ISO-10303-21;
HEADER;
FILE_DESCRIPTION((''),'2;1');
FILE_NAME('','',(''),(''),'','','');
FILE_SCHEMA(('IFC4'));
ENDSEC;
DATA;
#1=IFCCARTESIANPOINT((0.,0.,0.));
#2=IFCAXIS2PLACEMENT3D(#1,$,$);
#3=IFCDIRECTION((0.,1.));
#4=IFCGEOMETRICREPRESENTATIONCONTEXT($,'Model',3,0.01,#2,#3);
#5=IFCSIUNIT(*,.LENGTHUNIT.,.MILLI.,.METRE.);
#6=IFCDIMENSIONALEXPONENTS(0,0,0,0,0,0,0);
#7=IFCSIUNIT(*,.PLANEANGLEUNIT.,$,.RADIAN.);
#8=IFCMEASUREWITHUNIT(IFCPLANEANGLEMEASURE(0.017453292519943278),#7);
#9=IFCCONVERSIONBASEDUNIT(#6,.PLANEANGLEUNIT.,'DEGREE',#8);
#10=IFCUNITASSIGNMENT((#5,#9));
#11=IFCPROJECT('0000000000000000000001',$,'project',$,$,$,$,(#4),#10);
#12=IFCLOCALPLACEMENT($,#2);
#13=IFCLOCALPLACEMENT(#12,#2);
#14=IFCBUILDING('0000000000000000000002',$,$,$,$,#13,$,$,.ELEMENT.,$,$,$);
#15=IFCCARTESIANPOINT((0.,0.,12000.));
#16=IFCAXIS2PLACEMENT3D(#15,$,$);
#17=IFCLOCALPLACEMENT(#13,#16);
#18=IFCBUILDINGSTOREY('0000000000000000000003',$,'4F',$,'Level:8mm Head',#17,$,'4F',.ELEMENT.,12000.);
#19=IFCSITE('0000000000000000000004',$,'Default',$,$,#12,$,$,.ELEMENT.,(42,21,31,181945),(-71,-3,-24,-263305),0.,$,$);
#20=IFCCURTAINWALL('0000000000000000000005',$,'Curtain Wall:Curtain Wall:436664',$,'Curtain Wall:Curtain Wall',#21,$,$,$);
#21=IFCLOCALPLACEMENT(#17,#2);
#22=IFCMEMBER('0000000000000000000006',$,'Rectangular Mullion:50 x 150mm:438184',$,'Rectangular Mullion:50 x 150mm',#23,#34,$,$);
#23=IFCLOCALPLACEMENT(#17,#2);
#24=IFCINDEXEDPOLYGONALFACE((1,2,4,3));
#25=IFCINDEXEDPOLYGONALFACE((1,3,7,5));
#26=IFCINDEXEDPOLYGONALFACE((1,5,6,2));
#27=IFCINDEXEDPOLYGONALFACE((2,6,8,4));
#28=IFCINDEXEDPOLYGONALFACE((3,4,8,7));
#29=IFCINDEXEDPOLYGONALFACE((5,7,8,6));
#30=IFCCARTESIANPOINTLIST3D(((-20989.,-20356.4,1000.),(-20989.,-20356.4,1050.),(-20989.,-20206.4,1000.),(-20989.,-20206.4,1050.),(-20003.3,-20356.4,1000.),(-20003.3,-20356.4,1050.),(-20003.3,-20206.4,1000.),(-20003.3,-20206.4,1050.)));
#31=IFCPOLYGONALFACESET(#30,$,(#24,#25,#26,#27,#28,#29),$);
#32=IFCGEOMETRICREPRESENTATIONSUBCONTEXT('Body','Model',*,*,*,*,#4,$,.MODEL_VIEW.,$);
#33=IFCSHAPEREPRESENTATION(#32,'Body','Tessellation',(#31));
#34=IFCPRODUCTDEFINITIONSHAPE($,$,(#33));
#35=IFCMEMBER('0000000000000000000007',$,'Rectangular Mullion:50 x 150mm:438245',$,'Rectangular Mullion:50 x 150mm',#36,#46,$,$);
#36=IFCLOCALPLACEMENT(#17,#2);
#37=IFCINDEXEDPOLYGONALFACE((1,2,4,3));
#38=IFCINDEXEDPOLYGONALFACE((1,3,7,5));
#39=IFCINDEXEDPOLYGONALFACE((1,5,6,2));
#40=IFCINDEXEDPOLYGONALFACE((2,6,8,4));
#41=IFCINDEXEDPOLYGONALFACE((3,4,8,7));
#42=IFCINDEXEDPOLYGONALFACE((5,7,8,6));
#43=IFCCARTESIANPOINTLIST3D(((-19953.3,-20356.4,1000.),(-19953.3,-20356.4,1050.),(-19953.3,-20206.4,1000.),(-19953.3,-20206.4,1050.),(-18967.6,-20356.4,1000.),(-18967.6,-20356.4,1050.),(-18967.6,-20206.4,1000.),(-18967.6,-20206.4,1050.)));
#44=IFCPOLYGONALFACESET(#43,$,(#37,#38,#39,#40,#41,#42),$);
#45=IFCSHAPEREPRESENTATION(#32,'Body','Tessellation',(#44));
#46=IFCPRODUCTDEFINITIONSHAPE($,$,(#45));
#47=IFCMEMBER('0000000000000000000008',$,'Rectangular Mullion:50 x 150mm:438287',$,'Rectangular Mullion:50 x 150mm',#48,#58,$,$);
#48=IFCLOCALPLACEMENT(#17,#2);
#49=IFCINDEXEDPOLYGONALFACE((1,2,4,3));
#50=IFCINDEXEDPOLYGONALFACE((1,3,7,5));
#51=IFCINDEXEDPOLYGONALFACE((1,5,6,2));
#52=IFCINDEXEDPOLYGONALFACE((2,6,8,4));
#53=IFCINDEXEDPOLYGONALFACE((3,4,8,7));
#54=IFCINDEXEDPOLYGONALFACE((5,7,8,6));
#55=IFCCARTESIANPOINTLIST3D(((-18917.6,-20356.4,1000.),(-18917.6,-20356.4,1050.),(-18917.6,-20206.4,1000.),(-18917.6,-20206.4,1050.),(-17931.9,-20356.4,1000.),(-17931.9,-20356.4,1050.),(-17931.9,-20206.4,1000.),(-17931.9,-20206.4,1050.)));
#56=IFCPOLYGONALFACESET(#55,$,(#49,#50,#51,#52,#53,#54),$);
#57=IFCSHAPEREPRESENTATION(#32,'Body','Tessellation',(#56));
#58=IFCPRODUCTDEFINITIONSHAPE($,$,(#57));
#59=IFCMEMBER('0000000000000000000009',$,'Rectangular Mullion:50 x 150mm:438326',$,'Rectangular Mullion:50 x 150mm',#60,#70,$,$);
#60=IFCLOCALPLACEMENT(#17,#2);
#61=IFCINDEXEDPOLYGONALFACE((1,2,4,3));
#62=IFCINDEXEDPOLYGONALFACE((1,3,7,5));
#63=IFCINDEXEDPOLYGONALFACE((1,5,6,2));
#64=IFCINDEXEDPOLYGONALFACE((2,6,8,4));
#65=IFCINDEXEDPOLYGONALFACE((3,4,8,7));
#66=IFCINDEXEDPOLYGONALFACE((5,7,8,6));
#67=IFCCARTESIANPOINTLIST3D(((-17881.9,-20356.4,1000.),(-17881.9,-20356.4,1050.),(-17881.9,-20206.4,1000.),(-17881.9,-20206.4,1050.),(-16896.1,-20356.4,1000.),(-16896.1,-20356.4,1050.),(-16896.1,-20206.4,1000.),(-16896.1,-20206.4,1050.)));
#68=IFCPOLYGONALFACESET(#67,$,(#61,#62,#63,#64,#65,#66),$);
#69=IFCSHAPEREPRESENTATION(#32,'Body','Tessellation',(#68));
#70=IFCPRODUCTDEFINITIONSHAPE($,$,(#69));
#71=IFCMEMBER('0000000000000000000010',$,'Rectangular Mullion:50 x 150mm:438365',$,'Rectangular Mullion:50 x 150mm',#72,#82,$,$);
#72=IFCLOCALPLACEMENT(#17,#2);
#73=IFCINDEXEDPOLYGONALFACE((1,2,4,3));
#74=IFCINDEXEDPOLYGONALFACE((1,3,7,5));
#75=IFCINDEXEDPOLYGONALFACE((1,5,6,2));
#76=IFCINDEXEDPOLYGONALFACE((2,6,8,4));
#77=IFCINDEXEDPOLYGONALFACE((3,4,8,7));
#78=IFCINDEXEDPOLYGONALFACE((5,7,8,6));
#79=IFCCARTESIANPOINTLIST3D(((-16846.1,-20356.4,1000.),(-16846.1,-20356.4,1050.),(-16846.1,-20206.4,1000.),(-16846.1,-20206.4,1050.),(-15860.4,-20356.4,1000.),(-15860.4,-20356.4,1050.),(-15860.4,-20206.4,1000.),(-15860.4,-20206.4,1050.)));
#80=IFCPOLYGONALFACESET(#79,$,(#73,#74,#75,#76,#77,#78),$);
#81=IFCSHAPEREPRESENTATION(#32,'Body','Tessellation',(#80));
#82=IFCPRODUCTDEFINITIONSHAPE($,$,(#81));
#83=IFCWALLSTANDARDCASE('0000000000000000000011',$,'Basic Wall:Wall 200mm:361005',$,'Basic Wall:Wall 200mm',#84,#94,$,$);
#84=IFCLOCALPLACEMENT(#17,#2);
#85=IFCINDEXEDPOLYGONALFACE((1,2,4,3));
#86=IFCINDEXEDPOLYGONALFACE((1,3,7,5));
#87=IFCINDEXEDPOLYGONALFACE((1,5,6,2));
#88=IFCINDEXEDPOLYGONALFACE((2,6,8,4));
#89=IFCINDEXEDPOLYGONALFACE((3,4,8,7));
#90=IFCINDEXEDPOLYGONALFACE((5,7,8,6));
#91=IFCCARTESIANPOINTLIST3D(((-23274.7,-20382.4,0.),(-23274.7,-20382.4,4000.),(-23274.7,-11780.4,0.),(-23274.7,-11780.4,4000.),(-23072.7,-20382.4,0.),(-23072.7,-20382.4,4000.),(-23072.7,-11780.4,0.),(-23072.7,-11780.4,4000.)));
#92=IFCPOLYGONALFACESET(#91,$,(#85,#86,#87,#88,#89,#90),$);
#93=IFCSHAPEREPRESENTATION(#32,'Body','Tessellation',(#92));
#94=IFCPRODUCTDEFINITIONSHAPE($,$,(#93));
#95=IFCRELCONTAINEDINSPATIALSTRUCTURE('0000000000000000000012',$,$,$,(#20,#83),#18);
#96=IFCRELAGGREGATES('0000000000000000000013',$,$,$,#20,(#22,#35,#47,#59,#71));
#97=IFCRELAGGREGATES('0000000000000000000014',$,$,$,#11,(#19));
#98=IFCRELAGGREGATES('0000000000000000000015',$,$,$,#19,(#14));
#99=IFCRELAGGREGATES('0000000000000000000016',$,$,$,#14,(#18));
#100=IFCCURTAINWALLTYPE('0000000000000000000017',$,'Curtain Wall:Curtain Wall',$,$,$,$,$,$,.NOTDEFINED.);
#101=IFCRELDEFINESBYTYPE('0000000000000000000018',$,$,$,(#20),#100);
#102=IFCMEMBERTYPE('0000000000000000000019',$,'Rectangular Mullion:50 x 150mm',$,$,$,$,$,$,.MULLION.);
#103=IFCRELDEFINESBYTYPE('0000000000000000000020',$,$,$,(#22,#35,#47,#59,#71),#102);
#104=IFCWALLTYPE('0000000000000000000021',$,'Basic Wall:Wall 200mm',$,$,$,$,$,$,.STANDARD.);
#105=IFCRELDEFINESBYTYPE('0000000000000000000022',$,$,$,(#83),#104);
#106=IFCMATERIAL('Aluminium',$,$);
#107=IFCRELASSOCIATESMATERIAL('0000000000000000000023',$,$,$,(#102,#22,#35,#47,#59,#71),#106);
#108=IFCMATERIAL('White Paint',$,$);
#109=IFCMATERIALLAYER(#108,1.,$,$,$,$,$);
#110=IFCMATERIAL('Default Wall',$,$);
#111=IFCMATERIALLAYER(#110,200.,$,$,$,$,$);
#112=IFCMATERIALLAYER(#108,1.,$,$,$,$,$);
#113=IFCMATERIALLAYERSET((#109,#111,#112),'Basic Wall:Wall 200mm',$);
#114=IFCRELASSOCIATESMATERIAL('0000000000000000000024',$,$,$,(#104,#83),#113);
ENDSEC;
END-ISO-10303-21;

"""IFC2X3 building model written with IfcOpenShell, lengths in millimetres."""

from ifc_helpers import new_model, entity, si_unit, converted_unit, direction, frame, frame_2d, origin, origin_2d_with_axis, place, context, subcontext, project, spatial, rectangle, extrude, source, transform, mapped, material, layer, layer_set, layer_usage, type_object, type_shapes, element, aggregate, save


model = new_model("IFC2X3")

# Units and contexts
model_context = context("Model", 3, precision=0.01, world=origin(), true_north=direction((0.0, 1.0)))
body_context = subcontext(model_context, "Body", "Model", "MODEL_VIEW")
ifc_project = project(units=[si_unit("LENGTHUNIT", "METRE", prefix="MILLI"), converted_unit("PLANEANGLEUNIT", "DEGREE", entity("IfcPlaneAngleMeasure", 0.017453292519943278), si_unit("PLANEANGLEUNIT", "RADIAN"), dimensions=[0, 0, 0, 0, 0, 0, 0])], contexts=[model_context])

# Site, building, storey
site_placement = place(None, origin())
site = spatial("IfcSite", under=ifc_project, at=site_placement, Name="Default", CompositionType="ELEMENT", RefLatitude=(42, 21, 31, 181945), RefLongitude=(-71, -3, -24, -263305), RefElevation=0.0)
building_placement = place(site_placement, origin())
building = spatial("IfcBuilding", under=site, at=building_placement, CompositionType="ELEMENT")
storey_placement = place(building_placement, frame((0.0, 0.0, 12000.0)))
storey = spatial("IfcBuildingStorey", under=building, at=storey_placement, Name="4F", ObjectType="Level:8mm Head", LongName="4F", CompositionType="ELEMENT", Elevation=12000.0)

# Curtain wall, members
curtain_wall_type = type_object("IfcCurtainWallType", Name="Curtain Wall:Curtain Wall", PredefinedType="NOTDEFINED")
curtain_wall_placement = place(storey_placement, frame((0.0, 0.0, -12000.0)))
curtain_wall = element("IfcCurtainWall", 1, at=curtain_wall_placement, inside=storey, type_object=curtain_wall_type, Name="Curtain Wall:Curtain Wall:436664", ObjectType="Curtain Wall:Curtain Wall")
ifc_material_1 = material(Name="Aluminium")
member_type_1 = type_object("IfcMemberType", Name="Rectangular Mullion:50 x 150mm", PredefinedType="MULLION", material=ifc_material_1)
shared_shape_1 = source(origin(), body_context, "Body", "SweptSolid", [
    extrude(rectangle(XDim=50.0, YDim=150.0, at=origin_2d_with_axis()), frame((-25.0, 0.0, -985.7), z_axis=(0.0, 0.0, 1.0), x_axis=(-1.0, 0.0, 0.0)), (0.0, 0.0, 1.0), 985.7),
])
type_shapes(member_type_1, [shared_shape_1])
member_1_placement = place(curtain_wall_placement, frame((-20003.3, -20281.4, 13000.0), z_axis=(1.0, 0.0, 0.0), x_axis=(0.0, 0.0, -1.0)))
member_1 = element("IfcMember", 2, at=member_1_placement, type_object=member_type_1, material=ifc_material_1, Name="Rectangular Mullion:50 x 150mm:438184", ObjectType="Rectangular Mullion:50 x 150mm", context=body_context, shape_type="MappedRepresentation", body=[
    mapped(shared_shape_1, transform((0.0, 0.0, 0.0), scale=1.0)),
])
member_2_placement = place(curtain_wall_placement, frame((-18967.6, -20281.4, 13000.0), z_axis=(1.0, 0.0, 0.0), x_axis=(0.0, 0.0, -1.0)))
member_2 = element("IfcMember", 3, at=member_2_placement, type_object=member_type_1, material=ifc_material_1, Name="Rectangular Mullion:50 x 150mm:438245", ObjectType="Rectangular Mullion:50 x 150mm", context=body_context, shape_type="MappedRepresentation", body=[
    mapped(shared_shape_1, transform((0.0, 0.0, 0.0), scale=1.0)),
])
member_3_placement = place(curtain_wall_placement, frame((-17931.9, -20281.4, 13000.0), z_axis=(1.0, 0.0, 0.0), x_axis=(0.0, 0.0, -1.0)))
member_3 = element("IfcMember", 4, at=member_3_placement, type_object=member_type_1, material=ifc_material_1, Name="Rectangular Mullion:50 x 150mm:438287", ObjectType="Rectangular Mullion:50 x 150mm", context=body_context, shape_type="MappedRepresentation", body=[
    mapped(shared_shape_1, transform((0.0, 0.0, 0.0), scale=1.0)),
])
member_4_placement = place(curtain_wall_placement, frame((-16896.1, -20281.4, 13000.0), z_axis=(1.0, 0.0, 0.0), x_axis=(0.0, 0.0, -1.0)))
member_4 = element("IfcMember", 5, at=member_4_placement, type_object=member_type_1, material=ifc_material_1, Name="Rectangular Mullion:50 x 150mm:438326", ObjectType="Rectangular Mullion:50 x 150mm", context=body_context, shape_type="MappedRepresentation", body=[
    mapped(shared_shape_1, transform((0.0, 0.0, 0.0), scale=1.0)),
])
member_5_placement = place(curtain_wall_placement, frame((-15860.4, -20281.4, 13000.0), z_axis=(1.0, 0.0, 0.0), x_axis=(0.0, 0.0, -1.0)))
member_5 = element("IfcMember", 6, at=member_5_placement, type_object=member_type_1, material=ifc_material_1, Name="Rectangular Mullion:50 x 150mm:438365", ObjectType="Rectangular Mullion:50 x 150mm", context=body_context, shape_type="MappedRepresentation", body=[
    mapped(shared_shape_1, transform((0.0, 0.0, 0.0), scale=1.0)),
])

aggregate(curtain_wall, [member_1, member_2, member_3, member_4, member_5])

# Wall
ifc_material_2 = material(Name="White Paint")
ifc_layer_1 = layer(ifc_material_2, 1.0)
ifc_material_3 = material(Name="Default Wall")
ifc_layer_2 = layer(ifc_material_3, 200.0)
ifc_layer_3 = layer(ifc_material_2, 1.0)
ifc_layer_set_1 = layer_set([ifc_layer_1, ifc_layer_2, ifc_layer_3], Name="Basic Wall:Wall 200mm")
ifc_layer_usage_1 = layer_usage(ifc_layer_set_1, "AXIS2", "NEGATIVE", 101.0)
wall_type = type_object("IfcWallType", Name="Basic Wall:Wall 200mm", PredefinedType="STANDARD", material=ifc_layer_set_1)
wall_placement = place(storey_placement, frame((-23173.7, -20382.4, 0.0), z_axis=(0.0, 0.0, 1.0), x_axis=(0.0, 1.0, 0.0)))
element("IfcWallStandardCase", 7, at=wall_placement, inside=storey, type_object=wall_type, material=ifc_layer_usage_1, Name="Basic Wall:Wall 200mm:361005", ObjectType="Basic Wall:Wall 200mm", context=body_context, shape_type="SweptSolid", body=[
    extrude(rectangle(XDim=8602.0, YDim=202.0, at=frame_2d((4301.0, 0.0), x_axis=(-1.0, 0.0))), origin(), (0.0, 0.0, 1.0), 4000.0),
])

save(model, "model.ifc")
